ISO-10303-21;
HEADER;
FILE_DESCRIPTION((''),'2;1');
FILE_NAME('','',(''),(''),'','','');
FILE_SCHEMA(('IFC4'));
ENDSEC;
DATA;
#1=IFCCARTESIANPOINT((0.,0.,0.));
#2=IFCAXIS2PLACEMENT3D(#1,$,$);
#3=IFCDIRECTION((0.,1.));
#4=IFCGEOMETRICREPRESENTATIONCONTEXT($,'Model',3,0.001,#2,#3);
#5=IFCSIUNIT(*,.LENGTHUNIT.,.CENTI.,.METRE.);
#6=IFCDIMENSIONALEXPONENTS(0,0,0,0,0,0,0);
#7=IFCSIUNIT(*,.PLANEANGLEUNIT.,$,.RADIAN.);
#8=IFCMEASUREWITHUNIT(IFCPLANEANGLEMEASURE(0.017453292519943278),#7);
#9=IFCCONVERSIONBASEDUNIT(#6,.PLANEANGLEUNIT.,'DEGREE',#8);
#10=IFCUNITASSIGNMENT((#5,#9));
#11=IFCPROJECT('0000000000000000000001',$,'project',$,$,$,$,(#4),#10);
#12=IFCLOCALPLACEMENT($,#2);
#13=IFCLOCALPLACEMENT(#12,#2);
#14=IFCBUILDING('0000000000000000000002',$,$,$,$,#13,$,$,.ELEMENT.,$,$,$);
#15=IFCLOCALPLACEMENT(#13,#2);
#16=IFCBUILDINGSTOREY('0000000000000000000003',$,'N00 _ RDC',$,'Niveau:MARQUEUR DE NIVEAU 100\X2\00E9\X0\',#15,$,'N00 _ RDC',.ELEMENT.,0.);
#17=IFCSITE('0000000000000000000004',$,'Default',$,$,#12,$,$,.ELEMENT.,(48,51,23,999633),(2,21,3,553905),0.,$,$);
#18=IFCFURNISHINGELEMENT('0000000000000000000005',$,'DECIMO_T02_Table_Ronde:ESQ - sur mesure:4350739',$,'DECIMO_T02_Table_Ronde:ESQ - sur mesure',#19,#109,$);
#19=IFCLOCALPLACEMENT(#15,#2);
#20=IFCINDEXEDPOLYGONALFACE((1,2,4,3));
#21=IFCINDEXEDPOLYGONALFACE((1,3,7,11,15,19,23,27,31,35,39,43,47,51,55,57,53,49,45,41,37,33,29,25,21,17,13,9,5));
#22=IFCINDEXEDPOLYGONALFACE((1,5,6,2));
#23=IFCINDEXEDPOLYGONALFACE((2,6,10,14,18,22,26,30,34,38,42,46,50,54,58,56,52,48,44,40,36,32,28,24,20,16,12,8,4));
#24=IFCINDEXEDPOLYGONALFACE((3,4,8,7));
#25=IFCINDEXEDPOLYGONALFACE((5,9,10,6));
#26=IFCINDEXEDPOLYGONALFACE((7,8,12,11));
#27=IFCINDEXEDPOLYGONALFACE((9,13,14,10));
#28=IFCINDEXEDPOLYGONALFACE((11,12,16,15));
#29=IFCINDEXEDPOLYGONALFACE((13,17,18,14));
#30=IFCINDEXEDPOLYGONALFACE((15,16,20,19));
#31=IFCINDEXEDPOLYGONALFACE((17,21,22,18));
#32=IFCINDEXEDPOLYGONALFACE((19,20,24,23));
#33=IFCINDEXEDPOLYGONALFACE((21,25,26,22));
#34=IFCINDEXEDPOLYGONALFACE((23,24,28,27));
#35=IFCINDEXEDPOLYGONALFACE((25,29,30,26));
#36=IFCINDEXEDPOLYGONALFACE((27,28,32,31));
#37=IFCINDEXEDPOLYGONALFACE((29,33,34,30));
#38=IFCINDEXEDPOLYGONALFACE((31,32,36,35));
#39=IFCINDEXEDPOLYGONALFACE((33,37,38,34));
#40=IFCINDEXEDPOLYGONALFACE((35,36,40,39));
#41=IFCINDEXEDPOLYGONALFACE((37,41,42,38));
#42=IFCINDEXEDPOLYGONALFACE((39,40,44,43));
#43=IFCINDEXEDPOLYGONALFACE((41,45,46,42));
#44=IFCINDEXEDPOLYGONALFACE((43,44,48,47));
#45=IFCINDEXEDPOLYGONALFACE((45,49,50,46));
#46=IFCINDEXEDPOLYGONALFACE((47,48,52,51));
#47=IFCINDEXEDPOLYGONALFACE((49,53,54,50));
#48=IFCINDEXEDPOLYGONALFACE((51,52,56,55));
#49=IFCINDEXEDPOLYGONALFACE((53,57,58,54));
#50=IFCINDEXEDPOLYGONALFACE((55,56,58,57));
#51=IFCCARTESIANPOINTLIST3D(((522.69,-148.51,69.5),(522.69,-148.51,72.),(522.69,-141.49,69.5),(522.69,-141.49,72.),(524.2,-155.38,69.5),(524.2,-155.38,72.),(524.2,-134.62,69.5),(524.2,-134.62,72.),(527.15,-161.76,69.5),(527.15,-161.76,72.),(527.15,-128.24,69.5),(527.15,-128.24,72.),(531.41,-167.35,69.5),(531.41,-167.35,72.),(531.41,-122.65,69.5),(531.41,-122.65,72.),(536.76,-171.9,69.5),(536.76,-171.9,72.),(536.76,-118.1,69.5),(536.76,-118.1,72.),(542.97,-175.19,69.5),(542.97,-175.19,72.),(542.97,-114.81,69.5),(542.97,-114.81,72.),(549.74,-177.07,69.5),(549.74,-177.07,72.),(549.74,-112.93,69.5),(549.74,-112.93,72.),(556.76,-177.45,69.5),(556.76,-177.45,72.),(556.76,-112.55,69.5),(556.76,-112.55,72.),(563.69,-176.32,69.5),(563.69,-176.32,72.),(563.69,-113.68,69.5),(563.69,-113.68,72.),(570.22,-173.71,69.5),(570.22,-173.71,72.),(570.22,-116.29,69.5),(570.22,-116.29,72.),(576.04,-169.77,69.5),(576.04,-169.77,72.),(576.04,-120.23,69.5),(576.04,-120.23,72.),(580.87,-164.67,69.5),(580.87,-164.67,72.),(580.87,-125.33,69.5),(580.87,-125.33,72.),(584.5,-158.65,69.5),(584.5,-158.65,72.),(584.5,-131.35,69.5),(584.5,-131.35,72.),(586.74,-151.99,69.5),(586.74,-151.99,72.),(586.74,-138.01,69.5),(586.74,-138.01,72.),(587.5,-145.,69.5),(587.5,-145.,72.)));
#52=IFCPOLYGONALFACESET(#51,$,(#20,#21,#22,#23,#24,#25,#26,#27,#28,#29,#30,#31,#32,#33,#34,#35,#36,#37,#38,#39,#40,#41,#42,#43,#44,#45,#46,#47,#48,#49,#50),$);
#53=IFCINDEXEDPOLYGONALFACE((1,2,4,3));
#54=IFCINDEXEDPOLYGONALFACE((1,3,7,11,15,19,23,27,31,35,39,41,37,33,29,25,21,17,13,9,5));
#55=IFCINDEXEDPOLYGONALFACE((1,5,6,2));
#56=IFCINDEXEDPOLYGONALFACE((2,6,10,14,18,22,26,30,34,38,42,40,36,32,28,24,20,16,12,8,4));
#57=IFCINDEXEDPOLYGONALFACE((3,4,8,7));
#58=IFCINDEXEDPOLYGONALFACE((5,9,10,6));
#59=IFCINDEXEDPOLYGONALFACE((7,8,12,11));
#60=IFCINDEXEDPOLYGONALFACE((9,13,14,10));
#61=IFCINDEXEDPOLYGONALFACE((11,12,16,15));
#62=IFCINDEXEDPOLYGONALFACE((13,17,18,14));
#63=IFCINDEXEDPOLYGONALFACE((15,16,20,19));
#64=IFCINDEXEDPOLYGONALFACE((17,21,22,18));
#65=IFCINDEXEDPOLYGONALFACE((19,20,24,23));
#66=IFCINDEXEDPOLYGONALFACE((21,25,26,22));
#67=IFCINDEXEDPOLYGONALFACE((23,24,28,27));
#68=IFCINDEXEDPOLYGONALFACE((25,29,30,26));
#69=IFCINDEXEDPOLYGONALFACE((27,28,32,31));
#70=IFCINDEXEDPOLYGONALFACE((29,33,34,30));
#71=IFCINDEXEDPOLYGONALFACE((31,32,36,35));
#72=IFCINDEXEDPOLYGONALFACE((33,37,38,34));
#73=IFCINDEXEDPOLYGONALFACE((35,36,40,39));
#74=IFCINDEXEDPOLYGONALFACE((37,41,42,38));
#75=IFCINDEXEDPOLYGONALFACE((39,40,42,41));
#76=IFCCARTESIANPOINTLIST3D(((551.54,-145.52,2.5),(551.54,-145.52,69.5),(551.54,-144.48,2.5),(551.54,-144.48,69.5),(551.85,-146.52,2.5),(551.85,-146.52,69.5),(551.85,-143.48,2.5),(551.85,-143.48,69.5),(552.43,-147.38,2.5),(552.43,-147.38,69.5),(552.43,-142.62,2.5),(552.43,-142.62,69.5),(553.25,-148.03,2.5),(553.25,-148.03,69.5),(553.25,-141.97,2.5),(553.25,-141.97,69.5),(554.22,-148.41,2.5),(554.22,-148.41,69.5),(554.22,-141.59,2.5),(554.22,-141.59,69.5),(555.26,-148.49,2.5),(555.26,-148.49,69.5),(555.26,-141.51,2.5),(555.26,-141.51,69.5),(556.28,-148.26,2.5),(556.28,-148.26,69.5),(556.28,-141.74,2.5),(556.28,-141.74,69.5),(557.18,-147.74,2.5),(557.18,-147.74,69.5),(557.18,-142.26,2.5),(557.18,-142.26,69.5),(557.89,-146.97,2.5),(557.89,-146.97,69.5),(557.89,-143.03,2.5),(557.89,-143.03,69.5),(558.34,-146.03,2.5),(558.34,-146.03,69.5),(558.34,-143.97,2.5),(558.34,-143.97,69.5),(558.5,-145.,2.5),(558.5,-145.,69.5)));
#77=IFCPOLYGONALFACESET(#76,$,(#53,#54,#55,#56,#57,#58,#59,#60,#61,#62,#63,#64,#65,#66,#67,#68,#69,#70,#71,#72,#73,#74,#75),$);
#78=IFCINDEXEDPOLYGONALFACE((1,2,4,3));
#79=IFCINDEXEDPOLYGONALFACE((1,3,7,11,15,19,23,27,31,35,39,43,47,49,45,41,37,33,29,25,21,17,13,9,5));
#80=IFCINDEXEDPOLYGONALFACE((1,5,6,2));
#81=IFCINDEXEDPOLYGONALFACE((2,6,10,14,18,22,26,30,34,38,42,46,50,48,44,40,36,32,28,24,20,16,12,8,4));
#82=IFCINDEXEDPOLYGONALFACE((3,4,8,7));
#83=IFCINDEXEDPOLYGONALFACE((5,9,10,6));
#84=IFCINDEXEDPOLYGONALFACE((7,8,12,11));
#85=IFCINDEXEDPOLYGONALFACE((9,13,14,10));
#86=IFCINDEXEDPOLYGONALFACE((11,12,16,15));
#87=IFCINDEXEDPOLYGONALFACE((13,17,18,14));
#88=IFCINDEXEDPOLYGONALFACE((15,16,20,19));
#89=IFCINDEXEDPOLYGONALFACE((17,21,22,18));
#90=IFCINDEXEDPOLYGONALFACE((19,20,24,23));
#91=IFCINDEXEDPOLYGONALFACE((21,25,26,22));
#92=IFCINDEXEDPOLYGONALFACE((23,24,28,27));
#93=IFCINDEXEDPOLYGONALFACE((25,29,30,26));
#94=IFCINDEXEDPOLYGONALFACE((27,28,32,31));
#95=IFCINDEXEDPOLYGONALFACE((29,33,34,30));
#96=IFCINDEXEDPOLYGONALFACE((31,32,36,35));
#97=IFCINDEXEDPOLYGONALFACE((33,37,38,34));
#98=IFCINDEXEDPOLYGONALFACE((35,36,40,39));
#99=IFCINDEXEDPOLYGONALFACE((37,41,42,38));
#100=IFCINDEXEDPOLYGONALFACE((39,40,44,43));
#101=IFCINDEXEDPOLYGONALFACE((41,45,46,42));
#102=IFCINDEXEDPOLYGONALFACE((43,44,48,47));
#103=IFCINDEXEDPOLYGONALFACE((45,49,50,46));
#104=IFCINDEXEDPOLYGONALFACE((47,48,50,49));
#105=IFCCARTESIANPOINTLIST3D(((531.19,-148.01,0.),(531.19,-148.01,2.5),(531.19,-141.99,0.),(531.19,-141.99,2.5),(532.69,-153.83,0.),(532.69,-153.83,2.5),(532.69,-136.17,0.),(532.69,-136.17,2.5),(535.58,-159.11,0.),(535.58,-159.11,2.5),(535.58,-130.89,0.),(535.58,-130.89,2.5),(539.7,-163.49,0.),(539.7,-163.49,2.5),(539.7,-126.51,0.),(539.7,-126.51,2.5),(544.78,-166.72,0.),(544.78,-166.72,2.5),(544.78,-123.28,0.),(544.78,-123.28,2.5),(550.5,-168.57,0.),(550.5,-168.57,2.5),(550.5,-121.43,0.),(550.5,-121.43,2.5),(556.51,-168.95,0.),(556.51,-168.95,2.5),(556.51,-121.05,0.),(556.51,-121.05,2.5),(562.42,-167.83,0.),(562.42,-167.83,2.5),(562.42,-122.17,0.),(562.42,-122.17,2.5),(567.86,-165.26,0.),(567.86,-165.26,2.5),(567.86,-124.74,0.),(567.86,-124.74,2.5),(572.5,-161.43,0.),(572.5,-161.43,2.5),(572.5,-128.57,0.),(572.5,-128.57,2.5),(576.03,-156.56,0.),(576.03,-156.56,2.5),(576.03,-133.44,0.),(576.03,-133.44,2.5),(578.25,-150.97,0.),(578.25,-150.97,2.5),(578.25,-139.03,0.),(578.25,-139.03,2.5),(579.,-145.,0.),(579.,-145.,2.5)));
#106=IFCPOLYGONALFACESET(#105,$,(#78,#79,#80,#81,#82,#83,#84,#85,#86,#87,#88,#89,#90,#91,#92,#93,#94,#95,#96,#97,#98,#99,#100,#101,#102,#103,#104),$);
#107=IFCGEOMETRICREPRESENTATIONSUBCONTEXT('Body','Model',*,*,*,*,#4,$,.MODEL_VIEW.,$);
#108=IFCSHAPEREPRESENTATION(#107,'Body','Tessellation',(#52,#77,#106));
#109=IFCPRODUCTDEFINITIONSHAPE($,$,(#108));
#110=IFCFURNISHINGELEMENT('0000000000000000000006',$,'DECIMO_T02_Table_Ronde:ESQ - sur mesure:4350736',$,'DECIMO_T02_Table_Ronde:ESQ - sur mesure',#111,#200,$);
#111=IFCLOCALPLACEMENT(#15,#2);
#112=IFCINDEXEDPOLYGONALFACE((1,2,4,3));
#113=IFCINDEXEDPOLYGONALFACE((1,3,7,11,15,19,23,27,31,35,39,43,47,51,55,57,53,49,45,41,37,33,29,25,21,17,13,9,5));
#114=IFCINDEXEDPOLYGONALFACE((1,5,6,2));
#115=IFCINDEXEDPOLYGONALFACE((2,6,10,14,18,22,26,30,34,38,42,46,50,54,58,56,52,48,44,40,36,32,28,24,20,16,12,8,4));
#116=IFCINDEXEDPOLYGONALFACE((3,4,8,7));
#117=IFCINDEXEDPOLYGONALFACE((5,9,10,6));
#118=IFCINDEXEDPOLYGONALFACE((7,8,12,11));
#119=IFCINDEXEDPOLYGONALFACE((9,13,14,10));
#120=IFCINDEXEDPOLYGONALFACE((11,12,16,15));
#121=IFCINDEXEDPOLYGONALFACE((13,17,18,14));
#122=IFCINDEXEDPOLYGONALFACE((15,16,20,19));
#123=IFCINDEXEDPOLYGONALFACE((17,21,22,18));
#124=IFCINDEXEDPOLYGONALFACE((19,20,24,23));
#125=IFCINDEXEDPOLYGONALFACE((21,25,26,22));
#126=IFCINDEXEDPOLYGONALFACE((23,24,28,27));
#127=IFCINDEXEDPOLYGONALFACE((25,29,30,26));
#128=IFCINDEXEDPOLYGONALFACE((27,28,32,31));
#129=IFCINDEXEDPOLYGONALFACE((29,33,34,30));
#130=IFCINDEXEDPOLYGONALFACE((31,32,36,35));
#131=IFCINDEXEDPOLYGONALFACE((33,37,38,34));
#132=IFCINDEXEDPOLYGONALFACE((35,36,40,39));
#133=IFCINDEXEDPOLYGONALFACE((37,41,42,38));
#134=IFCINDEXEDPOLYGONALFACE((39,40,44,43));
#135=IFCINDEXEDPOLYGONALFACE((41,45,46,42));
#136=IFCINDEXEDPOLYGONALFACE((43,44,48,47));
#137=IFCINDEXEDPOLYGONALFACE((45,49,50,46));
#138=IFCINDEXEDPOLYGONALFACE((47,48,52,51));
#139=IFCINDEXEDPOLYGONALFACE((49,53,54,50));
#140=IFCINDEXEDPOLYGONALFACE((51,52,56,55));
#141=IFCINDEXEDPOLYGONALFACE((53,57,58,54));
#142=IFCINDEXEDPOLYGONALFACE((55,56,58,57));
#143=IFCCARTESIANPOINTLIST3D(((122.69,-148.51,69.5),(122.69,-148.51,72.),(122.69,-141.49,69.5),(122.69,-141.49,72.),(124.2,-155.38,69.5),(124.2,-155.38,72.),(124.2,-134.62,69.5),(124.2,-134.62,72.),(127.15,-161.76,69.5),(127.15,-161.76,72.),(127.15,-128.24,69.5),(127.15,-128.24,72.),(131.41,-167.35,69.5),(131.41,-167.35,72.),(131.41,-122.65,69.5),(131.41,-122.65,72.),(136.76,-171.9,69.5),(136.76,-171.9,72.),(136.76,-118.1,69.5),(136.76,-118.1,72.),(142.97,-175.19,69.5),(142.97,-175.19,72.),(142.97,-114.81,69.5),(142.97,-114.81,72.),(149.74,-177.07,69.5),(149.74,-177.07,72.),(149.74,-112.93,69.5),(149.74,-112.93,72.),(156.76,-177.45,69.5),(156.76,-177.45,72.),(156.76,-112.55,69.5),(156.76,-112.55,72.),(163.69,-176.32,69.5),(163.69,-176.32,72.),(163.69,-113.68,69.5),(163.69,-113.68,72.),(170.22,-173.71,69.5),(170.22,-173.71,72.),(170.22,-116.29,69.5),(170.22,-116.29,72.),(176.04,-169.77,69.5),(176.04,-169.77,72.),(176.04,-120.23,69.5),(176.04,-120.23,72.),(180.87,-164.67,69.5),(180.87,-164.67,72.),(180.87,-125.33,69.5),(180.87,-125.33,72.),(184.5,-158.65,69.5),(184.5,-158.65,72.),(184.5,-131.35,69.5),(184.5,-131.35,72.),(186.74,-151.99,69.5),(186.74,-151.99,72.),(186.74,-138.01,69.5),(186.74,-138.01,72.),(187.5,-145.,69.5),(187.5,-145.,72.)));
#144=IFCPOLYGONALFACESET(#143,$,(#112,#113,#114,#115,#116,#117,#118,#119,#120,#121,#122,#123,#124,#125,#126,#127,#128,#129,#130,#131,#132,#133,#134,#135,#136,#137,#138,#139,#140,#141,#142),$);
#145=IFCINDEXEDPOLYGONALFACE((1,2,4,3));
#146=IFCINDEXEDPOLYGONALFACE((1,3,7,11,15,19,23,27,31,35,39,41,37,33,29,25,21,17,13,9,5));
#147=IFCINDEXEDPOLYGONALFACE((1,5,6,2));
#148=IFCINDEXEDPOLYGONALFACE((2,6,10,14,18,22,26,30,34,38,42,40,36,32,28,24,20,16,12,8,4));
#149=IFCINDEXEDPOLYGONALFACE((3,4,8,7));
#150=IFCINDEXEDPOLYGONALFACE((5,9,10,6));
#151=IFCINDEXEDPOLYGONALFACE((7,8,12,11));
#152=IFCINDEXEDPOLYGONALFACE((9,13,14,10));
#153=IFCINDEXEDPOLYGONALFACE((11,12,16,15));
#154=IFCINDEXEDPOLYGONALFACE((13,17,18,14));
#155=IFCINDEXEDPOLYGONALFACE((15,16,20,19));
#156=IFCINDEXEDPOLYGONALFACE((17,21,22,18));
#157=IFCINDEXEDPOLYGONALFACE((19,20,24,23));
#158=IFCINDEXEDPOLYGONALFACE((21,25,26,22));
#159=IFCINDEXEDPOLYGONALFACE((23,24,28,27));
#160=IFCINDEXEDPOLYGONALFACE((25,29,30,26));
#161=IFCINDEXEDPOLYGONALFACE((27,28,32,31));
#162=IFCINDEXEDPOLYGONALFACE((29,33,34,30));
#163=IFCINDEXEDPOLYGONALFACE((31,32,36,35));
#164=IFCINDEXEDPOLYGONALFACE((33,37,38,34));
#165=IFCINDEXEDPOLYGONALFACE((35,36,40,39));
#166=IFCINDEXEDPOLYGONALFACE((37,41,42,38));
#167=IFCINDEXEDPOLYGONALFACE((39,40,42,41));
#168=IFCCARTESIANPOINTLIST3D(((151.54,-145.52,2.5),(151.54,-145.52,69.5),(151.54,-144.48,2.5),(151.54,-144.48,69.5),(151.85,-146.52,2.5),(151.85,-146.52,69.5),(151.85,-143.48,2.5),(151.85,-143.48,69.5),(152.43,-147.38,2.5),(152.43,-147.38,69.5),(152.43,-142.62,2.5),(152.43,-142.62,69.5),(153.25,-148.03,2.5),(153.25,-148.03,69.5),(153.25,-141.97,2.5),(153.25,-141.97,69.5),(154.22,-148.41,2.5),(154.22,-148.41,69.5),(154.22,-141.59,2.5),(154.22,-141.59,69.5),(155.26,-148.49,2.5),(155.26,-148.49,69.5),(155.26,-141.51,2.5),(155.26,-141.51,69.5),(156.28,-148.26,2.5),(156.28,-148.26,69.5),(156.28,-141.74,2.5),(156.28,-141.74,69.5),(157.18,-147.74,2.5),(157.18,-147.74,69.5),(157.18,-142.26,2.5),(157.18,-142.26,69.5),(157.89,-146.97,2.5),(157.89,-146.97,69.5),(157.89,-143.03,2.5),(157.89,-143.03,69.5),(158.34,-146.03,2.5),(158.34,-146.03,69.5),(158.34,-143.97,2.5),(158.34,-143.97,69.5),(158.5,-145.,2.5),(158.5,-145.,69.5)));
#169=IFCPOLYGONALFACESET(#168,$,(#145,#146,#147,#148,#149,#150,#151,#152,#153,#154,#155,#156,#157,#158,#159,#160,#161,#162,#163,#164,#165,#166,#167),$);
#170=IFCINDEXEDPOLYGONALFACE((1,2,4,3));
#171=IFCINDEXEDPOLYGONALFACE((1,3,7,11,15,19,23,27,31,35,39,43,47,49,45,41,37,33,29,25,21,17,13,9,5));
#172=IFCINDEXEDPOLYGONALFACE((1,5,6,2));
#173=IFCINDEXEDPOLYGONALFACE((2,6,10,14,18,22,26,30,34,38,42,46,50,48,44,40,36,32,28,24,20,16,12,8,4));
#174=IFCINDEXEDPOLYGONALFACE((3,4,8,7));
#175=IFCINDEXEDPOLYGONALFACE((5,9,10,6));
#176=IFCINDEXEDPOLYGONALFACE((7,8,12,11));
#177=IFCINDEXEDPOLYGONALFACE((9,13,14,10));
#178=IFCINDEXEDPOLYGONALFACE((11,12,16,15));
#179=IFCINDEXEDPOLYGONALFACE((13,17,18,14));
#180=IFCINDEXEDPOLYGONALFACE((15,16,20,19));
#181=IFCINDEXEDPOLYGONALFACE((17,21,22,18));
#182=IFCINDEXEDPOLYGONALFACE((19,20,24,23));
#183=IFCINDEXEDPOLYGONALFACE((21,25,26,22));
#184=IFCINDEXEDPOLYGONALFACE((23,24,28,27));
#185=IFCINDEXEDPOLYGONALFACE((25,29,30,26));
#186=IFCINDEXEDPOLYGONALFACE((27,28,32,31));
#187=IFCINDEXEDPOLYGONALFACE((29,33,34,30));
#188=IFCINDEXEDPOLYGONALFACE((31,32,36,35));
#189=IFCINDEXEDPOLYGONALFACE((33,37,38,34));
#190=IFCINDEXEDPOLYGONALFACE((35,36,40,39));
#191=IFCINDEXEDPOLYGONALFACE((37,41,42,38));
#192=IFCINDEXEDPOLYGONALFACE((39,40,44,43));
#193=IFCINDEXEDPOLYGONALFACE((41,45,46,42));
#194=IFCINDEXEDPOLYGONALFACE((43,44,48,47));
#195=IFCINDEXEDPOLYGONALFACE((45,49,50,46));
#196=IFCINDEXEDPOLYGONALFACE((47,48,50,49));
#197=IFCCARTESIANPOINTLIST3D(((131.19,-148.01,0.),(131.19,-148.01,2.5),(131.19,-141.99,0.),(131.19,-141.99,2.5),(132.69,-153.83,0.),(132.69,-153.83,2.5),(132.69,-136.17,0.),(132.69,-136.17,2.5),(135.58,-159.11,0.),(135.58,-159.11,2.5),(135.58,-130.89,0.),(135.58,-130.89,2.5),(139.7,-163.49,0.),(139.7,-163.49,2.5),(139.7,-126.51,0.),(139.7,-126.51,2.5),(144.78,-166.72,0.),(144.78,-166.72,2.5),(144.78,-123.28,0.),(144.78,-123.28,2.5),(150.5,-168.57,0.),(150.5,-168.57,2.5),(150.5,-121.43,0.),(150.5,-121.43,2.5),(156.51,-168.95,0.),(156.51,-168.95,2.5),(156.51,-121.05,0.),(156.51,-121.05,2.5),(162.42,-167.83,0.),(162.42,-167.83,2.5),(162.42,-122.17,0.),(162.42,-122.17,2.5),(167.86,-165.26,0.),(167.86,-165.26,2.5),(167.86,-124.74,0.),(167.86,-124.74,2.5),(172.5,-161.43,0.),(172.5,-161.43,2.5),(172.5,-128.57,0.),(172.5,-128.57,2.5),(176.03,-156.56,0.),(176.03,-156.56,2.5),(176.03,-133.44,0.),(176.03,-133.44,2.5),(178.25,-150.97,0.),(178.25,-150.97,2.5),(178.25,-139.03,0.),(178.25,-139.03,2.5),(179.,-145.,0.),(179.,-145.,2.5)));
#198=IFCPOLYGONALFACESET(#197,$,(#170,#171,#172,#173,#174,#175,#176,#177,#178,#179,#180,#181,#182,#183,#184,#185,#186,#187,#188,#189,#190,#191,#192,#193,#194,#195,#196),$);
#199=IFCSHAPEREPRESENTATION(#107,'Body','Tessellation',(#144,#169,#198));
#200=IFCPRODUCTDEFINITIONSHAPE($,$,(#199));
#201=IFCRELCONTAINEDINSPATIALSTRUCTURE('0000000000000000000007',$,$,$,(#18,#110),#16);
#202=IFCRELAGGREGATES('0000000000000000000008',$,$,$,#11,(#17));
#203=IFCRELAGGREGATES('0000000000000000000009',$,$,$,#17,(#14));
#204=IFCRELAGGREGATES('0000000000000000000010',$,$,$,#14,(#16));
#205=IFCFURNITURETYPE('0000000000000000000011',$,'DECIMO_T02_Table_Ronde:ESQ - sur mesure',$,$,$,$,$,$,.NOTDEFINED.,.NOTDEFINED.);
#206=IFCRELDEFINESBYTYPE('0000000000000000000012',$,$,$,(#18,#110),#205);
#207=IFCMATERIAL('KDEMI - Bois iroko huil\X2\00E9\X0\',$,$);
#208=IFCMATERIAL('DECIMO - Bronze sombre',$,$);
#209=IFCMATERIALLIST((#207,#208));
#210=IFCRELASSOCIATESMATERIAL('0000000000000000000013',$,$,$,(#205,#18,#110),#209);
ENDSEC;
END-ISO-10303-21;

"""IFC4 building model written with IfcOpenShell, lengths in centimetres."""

from ifc_helpers import new_model, entity, si_unit, converted_unit, direction, frame, frame_2d, origin, place, context, subcontext, project, spatial, circle, extrude, source, transform, mapped, material, material_list, type_object, type_shapes, element, save


model = new_model("IFC4")

# Units and contexts
model_context = context("Model", 3, precision=0.001, world=origin(), true_north=direction((0.0, 1.0)))
body_context = subcontext(model_context, "Body", "Model", "MODEL_VIEW")
ifc_project = project(units=[si_unit("LENGTHUNIT", "METRE", prefix="CENTI"), converted_unit("PLANEANGLEUNIT", "DEGREE", entity("IfcPlaneAngleMeasure", 0.017453292519943278), si_unit("PLANEANGLEUNIT", "RADIAN"), dimensions=[0, 0, 0, 0, 0, 0, 0])], contexts=[model_context])

# Site, building, storey
site_placement = place(None, origin())
site = spatial("IfcSite", under=ifc_project, at=site_placement, Name="Default", CompositionType="ELEMENT", RefLatitude=(48, 51, 23, 999633), RefLongitude=(2, 21, 3, 553905), RefElevation=0.0)
building_placement = place(site_placement, origin())
building = spatial("IfcBuilding", under=site, at=building_placement, CompositionType="ELEMENT")
storey_placement = place(building_placement, origin())
storey = spatial("IfcBuildingStorey", under=building, at=storey_placement, Name="N00 _ RDC", ObjectType="Niveau:MARQUEUR DE NIVEAU 100é", LongName="N00 _ RDC", CompositionType="ELEMENT", Elevation=0.0)

# Furnishing elements
ifc_material_1 = material(Name="KDEMI - Bois iroko huilé")
ifc_material_2 = material(Name="DECIMO - Bronze sombre")
ifc_material_list_1 = material_list([ifc_material_1, ifc_material_2])
furniture_type_1 = type_object("IfcFurnitureType", Name="DECIMO_T02_Table_Ronde:ESQ - sur mesure", AssemblyPlace="NOTDEFINED", material=ifc_material_list_1)
shared_shape_1 = source(origin(), body_context, "Body", "SweptSolid", [
    extrude(circle(Radius=32.5, at=frame_2d((0.0, 0.0), x_axis=(1.0, 0.0))), frame((0.0, 0.0, 69.5)), (0.0, 0.0, 1.0), 2.5),
    extrude(circle(Radius=3.5, at=frame_2d((0.0, 0.0), x_axis=(1.0, 0.0))), frame((0.0, 0.0, 2.5)), (0.0, 0.0, 1.0), 67.0),
    extrude(circle(Radius=24.0, at=frame_2d((0.0, 0.0), x_axis=(1.0, 0.0))), origin(), (0.0, 0.0, 1.0), 2.5),
])
type_shapes(furniture_type_1, [shared_shape_1])
furnishing_1_placement = place(storey_placement, frame((555.0, -145.0, 0.0), z_axis=(0.0, 0.0, 1.0), x_axis=(1.0, 0.0, 0.0)))
element("IfcFurnishingElement", 1, at=furnishing_1_placement, inside=storey, type_object=furniture_type_1, material=ifc_material_list_1, Name="DECIMO_T02_Table_Ronde:ESQ - sur mesure:4350739", ObjectType="DECIMO_T02_Table_Ronde:ESQ - sur mesure", context=body_context, shape_type="MappedRepresentation", body=[
    mapped(shared_shape_1, transform((0.0, 0.0, 0.0), scale=1.0)),
])
furnishing_2_placement = place(storey_placement, frame((155.0, -145.0, 0.0)))
element("IfcFurnishingElement", 2, at=furnishing_2_placement, inside=storey, type_object=furniture_type_1, material=ifc_material_list_1, Name="DECIMO_T02_Table_Ronde:ESQ - sur mesure:4350736", ObjectType="DECIMO_T02_Table_Ronde:ESQ - sur mesure", context=body_context, shape_type="MappedRepresentation", body=[
    mapped(shared_shape_1, transform((0.0, 0.0, 0.0), scale=1.0)),
])

save(model, "model.ifc")
